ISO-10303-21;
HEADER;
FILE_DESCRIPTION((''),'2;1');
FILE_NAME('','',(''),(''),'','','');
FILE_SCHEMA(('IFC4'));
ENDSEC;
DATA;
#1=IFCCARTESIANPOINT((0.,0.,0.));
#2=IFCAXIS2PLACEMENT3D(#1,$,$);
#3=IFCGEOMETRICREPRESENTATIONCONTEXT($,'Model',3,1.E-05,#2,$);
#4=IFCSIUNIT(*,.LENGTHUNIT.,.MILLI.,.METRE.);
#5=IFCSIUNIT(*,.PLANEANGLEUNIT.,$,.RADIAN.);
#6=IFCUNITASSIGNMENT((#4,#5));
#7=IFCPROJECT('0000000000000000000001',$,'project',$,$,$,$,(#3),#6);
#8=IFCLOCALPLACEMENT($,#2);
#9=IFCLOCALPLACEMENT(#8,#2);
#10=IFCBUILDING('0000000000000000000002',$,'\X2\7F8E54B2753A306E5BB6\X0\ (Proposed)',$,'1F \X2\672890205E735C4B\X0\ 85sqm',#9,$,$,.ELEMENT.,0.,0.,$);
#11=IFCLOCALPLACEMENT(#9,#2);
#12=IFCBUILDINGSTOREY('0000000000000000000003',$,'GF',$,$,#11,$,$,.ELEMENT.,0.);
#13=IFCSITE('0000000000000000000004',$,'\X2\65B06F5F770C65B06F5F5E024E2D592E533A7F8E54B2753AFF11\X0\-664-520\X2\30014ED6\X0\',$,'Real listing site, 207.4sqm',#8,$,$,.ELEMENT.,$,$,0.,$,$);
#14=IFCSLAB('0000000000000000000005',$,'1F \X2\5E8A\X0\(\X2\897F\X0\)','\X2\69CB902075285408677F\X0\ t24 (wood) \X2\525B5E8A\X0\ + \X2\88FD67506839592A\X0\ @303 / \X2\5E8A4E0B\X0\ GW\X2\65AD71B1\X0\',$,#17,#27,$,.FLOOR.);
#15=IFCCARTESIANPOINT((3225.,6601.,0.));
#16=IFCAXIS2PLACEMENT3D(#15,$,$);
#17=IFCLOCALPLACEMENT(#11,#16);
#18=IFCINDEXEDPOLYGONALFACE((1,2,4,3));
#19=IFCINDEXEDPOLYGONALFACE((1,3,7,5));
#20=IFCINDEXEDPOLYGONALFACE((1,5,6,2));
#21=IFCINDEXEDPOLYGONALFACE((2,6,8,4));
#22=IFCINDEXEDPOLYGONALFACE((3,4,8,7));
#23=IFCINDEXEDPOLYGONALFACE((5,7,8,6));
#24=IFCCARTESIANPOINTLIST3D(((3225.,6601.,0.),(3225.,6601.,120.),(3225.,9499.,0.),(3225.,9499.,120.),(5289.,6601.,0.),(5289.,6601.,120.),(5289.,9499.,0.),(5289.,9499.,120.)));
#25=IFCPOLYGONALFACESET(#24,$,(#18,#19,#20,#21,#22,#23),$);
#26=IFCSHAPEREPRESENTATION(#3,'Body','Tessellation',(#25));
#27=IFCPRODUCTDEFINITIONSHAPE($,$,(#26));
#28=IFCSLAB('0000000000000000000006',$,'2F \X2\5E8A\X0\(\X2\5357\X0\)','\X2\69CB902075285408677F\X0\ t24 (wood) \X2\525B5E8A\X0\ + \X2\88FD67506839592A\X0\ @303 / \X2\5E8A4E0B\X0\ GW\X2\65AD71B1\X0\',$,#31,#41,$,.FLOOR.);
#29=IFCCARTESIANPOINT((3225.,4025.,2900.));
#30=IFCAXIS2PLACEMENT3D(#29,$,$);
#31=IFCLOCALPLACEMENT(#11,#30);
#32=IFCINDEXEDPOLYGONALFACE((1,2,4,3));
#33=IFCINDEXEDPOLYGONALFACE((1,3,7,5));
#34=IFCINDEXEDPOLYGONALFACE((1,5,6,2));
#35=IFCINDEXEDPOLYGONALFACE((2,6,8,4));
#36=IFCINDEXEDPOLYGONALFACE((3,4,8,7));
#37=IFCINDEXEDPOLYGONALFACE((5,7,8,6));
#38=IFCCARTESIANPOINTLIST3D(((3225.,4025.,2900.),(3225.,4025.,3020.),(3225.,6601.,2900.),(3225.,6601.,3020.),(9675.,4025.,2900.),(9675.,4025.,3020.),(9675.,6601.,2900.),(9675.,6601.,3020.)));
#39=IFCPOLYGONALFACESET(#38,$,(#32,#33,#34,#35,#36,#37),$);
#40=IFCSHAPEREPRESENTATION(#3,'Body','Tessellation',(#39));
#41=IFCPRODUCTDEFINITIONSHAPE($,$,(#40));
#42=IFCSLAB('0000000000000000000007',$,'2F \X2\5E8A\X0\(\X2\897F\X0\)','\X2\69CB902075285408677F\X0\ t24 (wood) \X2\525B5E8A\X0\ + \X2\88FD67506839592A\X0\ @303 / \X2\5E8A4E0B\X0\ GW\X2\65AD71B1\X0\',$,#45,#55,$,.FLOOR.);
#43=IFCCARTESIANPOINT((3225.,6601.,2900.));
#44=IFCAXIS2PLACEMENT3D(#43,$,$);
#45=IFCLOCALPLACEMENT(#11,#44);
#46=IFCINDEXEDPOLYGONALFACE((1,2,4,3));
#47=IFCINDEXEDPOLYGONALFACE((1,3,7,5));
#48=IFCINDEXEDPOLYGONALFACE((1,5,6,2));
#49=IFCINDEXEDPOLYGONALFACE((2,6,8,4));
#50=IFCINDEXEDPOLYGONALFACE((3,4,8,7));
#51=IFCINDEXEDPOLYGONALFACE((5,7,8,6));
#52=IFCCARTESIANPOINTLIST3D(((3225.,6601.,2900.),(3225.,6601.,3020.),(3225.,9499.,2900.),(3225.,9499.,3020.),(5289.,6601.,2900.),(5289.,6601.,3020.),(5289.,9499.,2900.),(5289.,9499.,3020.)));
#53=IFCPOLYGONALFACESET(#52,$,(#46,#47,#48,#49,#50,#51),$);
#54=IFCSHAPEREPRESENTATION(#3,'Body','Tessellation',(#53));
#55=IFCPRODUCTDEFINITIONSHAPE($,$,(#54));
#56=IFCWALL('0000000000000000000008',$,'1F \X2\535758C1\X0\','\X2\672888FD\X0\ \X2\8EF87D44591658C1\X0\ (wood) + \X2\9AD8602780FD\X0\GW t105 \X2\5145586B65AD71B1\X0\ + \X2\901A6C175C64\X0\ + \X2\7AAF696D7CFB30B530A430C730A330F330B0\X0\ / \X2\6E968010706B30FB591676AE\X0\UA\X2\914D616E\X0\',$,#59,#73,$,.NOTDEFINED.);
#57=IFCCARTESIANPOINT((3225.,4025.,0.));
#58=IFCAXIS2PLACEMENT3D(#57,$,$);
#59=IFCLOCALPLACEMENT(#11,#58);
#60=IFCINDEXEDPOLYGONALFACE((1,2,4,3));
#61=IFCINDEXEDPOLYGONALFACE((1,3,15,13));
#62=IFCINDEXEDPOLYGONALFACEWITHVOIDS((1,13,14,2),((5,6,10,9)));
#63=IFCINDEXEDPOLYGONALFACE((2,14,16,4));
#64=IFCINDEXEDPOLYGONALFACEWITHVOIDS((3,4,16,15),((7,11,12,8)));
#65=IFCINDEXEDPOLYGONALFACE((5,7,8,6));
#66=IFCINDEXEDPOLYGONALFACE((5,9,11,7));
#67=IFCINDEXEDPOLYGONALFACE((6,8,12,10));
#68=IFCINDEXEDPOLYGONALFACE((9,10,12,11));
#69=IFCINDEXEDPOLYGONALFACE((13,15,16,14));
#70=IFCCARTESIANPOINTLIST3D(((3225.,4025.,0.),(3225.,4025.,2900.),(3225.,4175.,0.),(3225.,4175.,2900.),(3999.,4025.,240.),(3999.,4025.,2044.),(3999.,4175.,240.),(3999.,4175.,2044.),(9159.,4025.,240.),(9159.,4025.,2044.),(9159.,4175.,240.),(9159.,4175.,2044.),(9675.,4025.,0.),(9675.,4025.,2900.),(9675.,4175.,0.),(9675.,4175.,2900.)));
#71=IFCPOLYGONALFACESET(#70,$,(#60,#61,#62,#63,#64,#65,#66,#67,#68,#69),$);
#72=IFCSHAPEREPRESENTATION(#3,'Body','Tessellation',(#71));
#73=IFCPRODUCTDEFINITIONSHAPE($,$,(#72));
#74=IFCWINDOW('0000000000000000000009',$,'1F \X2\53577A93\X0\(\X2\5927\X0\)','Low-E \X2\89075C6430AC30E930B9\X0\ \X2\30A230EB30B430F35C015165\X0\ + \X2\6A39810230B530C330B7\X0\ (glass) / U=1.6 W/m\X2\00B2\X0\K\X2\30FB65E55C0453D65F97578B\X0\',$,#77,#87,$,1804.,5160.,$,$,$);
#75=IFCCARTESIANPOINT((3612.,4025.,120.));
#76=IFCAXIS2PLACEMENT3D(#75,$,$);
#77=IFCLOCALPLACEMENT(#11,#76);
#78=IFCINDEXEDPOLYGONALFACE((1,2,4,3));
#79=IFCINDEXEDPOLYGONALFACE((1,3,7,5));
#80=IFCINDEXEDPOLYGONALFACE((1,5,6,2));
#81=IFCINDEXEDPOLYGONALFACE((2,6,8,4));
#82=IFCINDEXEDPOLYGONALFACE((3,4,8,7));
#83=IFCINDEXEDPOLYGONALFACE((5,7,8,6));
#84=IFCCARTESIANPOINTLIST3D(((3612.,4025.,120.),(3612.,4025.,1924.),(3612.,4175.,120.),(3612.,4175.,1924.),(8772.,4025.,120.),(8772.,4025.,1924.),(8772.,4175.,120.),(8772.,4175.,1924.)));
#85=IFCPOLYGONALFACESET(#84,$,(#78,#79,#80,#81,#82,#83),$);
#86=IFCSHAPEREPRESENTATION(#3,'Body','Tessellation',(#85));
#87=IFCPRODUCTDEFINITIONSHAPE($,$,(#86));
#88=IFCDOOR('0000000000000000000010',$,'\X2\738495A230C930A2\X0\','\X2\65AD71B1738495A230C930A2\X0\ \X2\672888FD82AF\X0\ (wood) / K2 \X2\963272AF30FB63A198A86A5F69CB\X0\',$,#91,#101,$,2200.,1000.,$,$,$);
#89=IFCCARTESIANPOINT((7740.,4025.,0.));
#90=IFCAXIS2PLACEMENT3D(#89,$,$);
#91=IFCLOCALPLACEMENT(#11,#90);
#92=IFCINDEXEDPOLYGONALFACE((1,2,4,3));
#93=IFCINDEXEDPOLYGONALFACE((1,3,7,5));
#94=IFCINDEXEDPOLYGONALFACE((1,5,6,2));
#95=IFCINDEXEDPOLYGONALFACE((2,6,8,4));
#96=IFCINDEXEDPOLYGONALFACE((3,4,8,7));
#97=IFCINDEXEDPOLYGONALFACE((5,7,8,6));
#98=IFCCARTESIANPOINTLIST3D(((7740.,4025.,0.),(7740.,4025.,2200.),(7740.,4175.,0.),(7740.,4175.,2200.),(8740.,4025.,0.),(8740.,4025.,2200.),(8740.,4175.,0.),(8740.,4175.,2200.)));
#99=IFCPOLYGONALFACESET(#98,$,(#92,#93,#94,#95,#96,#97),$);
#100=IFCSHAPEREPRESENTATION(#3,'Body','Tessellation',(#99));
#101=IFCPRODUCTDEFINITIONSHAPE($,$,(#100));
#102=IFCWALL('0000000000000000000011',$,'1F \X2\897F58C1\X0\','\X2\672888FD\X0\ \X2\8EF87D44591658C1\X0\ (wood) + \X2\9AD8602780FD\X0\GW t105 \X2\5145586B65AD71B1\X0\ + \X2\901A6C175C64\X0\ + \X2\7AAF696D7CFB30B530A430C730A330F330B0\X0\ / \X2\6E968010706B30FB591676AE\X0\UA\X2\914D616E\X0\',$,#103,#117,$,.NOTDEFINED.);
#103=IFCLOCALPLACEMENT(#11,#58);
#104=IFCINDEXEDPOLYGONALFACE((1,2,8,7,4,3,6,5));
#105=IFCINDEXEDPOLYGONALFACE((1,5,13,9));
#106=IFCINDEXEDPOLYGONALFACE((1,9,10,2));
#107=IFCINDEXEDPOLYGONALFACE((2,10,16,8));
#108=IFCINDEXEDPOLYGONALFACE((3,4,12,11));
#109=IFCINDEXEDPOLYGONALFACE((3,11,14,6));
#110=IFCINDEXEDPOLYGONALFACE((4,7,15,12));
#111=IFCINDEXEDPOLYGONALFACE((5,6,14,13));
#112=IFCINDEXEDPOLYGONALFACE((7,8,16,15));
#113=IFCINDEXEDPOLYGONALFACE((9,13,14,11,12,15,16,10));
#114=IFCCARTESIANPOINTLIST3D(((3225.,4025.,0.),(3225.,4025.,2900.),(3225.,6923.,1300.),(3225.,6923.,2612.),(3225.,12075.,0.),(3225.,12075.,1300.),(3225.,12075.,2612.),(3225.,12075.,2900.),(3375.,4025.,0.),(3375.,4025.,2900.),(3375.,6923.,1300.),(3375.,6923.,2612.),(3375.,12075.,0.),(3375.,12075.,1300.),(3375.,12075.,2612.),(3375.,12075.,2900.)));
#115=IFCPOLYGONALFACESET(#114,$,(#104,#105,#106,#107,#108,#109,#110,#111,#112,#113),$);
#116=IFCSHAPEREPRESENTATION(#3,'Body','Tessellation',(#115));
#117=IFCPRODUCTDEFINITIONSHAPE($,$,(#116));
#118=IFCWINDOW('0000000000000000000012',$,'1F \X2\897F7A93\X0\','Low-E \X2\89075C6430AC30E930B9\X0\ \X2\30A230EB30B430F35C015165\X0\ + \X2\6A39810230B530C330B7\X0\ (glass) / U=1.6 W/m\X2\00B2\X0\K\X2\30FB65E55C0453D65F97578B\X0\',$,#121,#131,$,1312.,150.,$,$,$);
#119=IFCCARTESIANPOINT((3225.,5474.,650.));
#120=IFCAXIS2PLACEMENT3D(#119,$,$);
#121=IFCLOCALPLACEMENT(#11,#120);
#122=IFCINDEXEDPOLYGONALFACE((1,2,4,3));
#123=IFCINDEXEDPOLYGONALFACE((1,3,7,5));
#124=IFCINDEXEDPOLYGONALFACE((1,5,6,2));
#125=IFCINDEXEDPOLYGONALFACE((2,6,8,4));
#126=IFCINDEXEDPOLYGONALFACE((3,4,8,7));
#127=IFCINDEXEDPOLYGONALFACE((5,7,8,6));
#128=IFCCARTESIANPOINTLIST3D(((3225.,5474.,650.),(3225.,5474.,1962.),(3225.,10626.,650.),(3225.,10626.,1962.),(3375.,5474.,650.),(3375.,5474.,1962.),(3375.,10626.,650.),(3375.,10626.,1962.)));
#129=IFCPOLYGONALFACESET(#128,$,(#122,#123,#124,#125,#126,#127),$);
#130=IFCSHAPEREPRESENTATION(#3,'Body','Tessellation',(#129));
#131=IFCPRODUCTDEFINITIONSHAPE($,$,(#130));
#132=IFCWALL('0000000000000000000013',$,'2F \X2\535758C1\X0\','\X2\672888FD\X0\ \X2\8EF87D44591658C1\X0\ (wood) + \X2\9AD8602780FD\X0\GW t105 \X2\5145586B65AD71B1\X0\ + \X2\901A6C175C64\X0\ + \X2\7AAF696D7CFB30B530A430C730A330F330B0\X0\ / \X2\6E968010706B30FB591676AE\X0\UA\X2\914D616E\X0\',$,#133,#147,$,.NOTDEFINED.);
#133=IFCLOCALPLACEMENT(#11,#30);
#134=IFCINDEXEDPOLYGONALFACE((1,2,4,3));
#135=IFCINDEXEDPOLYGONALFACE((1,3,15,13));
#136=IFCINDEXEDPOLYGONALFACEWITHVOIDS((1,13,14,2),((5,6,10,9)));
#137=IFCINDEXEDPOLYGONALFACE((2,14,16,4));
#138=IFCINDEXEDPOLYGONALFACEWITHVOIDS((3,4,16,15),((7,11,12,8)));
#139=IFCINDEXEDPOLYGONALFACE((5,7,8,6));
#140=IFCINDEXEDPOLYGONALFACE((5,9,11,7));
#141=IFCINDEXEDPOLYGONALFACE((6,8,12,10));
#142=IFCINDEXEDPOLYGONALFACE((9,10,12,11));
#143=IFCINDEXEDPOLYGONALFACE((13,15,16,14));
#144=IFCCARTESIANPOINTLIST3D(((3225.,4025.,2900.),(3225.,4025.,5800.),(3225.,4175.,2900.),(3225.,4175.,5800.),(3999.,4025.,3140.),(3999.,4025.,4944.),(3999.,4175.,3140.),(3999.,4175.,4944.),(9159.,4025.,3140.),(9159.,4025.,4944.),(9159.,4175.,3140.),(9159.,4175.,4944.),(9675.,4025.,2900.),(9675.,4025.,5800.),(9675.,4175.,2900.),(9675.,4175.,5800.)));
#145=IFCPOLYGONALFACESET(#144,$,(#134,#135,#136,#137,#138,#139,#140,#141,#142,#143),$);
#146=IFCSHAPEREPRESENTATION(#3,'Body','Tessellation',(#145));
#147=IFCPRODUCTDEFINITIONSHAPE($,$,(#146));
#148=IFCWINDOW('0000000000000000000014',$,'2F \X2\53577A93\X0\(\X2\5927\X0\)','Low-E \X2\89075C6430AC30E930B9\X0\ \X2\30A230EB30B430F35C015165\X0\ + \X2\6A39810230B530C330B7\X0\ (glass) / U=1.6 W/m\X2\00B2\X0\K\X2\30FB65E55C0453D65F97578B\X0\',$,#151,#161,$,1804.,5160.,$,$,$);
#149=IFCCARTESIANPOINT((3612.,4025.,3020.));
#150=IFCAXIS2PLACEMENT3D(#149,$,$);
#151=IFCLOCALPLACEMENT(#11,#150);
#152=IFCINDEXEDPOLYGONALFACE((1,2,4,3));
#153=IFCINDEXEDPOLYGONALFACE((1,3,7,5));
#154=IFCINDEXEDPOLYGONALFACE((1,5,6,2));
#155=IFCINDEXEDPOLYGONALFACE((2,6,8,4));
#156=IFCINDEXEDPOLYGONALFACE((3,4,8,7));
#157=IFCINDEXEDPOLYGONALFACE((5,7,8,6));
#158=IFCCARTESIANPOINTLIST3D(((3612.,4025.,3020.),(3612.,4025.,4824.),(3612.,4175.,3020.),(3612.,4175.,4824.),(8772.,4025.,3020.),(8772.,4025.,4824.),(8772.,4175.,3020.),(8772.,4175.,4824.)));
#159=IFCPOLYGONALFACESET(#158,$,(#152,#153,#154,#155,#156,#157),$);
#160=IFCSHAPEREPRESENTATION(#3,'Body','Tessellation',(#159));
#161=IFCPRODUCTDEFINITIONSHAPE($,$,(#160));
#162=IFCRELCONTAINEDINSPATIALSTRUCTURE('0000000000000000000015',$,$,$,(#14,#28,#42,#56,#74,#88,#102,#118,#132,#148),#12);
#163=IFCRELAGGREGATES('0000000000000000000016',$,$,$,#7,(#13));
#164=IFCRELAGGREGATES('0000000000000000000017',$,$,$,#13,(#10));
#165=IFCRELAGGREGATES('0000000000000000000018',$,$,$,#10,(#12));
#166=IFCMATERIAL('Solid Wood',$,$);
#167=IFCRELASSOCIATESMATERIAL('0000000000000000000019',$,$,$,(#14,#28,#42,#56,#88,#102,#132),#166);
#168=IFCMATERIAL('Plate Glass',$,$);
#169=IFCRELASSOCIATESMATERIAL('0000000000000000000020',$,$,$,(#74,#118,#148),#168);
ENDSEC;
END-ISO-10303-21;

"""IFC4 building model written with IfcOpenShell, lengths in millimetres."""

from ifc_helpers import new_model, si_unit, frame, frame_2d, origin, place, context, project, spatial, rectangle, extrude, material, element, fill, save


model = new_model("IFC4")

# Units and contexts
model_context = context("Model", 3, precision=1e-05, world=origin())
ifc_project = project(units=[si_unit("LENGTHUNIT", "METRE", prefix="MILLI"), si_unit("PLANEANGLEUNIT", "RADIAN")], contexts=[model_context])

# Site, building, storey
site_placement = place(None, origin())
site = spatial("IfcSite", under=ifc_project, at=site_placement, Name="新潟県新潟市中央区美咲町１-664-520、他", ObjectType="Real listing site, 207.4sqm", CompositionType="ELEMENT", RefElevation=0.0)
building_placement = place(site_placement, origin())
building = spatial("IfcBuilding", under=site, at=building_placement, Name="美咲町の家 (Proposed)", ObjectType="1F 木造平屋 85sqm", CompositionType="ELEMENT", ElevationOfRefHeight=0.0, ElevationOfTerrain=0.0)
storey_placement = place(building_placement, origin())
storey = spatial("IfcBuildingStorey", under=building, at=storey_placement, Name="GF", CompositionType="ELEMENT", Elevation=0.0)

# Slabs
ifc_material_1 = material(Name="Solid Wood")
slab_1_placement = place(storey_placement, frame((3225.0, 6601.0, 0.0)))
element("IfcSlab", 1, at=slab_1_placement, inside=storey, material=ifc_material_1, Name="1F 床(西)", Description="構造用合板 t24 (wood) 剛床 + 製材根太 @303 / 床下 GW断熱", PredefinedType="FLOOR", context=model_context, shape_type="SweptSolid", body=[
    extrude(rectangle(XDim=2064.0, YDim=2898.0, at=frame_2d((1032.0, 1449.0))), frame((3225.0, 6601.0, 0.0)), (0.0, 0.0, 1.0), 120.0),
])
slab_2_placement = place(storey_placement, frame((3225.0, 4025.0, 2900.0)))
element("IfcSlab", 2, at=slab_2_placement, inside=storey, material=ifc_material_1, Name="2F 床(南)", Description="構造用合板 t24 (wood) 剛床 + 製材根太 @303 / 床下 GW断熱", PredefinedType="FLOOR", context=model_context, shape_type="SweptSolid", body=[
    extrude(rectangle(XDim=6450.0, YDim=2576.0, at=frame_2d((3225.0, 1288.0))), frame((3225.0, 4025.0, 2900.0)), (0.0, 0.0, 1.0), 120.0),
])
slab_3_placement = place(storey_placement, frame((3225.0, 6601.0, 2900.0)))
element("IfcSlab", 3, at=slab_3_placement, inside=storey, material=ifc_material_1, Name="2F 床(西)", Description="構造用合板 t24 (wood) 剛床 + 製材根太 @303 / 床下 GW断熱", PredefinedType="FLOOR", context=model_context, shape_type="SweptSolid", body=[
    extrude(rectangle(XDim=2064.0, YDim=2898.0, at=frame_2d((1032.0, 1449.0))), frame((3225.0, 6601.0, 2900.0)), (0.0, 0.0, 1.0), 120.0),
])

# Wall, openings, window, door
wall_1_placement = place(storey_placement, frame((3225.0, 4025.0, 0.0)))
wall_1 = element("IfcWall", 4, at=wall_1_placement, inside=storey, material=ifc_material_1, Name="1F 南壁", Description="木製 軸組外壁 (wood) + 高性能GW t105 充填断熱 + 通気層 + 窯業系サイディング / 準耐火・外皮UA配慮", PredefinedType="NOTDEFINED", context=model_context, shape_type="SweptSolid", body=[
    extrude(rectangle(XDim=6450.0, YDim=150.0, at=frame_2d((3225.0, 75.0))), frame((3225.0, 4025.0, 0.0)), (0.0, 0.0, 1.0), 2900.0),
])
opening_1_placement = place(storey_placement, frame((3612.0, 4025.0, 120.0)))
opening_1 = element("IfcOpeningElement", 5, at=opening_1_placement, cuts=wall_1, PredefinedType="NOTDEFINED", context=model_context, shape_type="SweptSolid", body=[
    extrude(rectangle(XDim=5160.0, YDim=150.0, at=frame_2d((2580.0, 75.0))), frame((3612.0, 4025.0, 120.0)), (0.0, 0.0, 1.0), 1804.0),
])
opening_2_placement = place(storey_placement, frame((7740.0, 4025.0, 0.0)))
opening_2 = element("IfcOpeningElement", 6, at=opening_2_placement, cuts=wall_1, PredefinedType="NOTDEFINED", context=model_context, shape_type="SweptSolid", body=[
    extrude(rectangle(XDim=1000.0, YDim=150.0, at=frame_2d((500.0, 75.0))), frame((7740.0, 4025.0, 0.0)), (0.0, 0.0, 1.0), 2200.0),
])
ifc_material_2 = material(Name="Plate Glass")
window_1_placement = place(storey_placement, frame((3612.0, 4025.0, 120.0)))
window_1 = element("IfcWindow", 7, at=window_1_placement, inside=storey, material=ifc_material_2, Name="1F 南窓(大)", Description="Low-E 複層ガラス アルゴン封入 + 樹脂サッシ (glass) / U=1.6 W/m²K・日射取得型", OverallHeight=1804.0, OverallWidth=5160.0, context=model_context, shape_type="SweptSolid", body=[
    extrude(rectangle(XDim=5160.0, YDim=150.0, at=frame_2d((2580.0, 75.0))), frame((3612.0, 4025.0, 120.0)), (0.0, 0.0, 1.0), 1804.0),
])
fill(opening_1, window_1)
door_placement = place(storey_placement, frame((7740.0, 4025.0, 0.0)))
door = element("IfcDoor", 8, at=door_placement, inside=storey, material=ifc_material_1, Name="玄関ドア", Description="断熱玄関ドア 木製芯 (wood) / K2 防犯・採風機構", OverallHeight=2200.0, OverallWidth=1000.0, context=model_context, shape_type="SweptSolid", body=[
    extrude(rectangle(XDim=1000.0, YDim=150.0, at=frame_2d((500.0, 75.0))), frame((7740.0, 4025.0, 0.0)), (0.0, 0.0, 1.0), 2200.0),
])
fill(opening_2, door)

# Walls, openings, windows
wall_2_placement = place(storey_placement, frame((3225.0, 4025.0, 0.0)))
wall_2 = element("IfcWall", 9, at=wall_2_placement, inside=storey, material=ifc_material_1, Name="1F 西壁", Description="木製 軸組外壁 (wood) + 高性能GW t105 充填断熱 + 通気層 + 窯業系サイディング / 準耐火・外皮UA配慮", PredefinedType="NOTDEFINED", context=model_context, shape_type="SweptSolid", body=[
    extrude(rectangle(XDim=150.0, YDim=8050.0, at=frame_2d((75.0, 4025.0))), frame((3225.0, 4025.0, 0.0)), (0.0, 0.0, 1.0), 2900.0),
])
opening_3_placement = place(storey_placement, frame((3225.0, 5474.0, 650.0)))
opening_3 = element("IfcOpeningElement", 10, at=opening_3_placement, cuts=wall_2, PredefinedType="NOTDEFINED", context=model_context, shape_type="SweptSolid", body=[
    extrude(rectangle(XDim=150.0, YDim=5152.0, at=frame_2d((75.0, 2576.0))), frame((3225.0, 5474.0, 650.0)), (0.0, 0.0, 1.0), 1312.0),
])
window_2_placement = place(storey_placement, frame((3225.0, 5474.0, 650.0)))
window_2 = element("IfcWindow", 11, at=window_2_placement, inside=storey, material=ifc_material_2, Name="1F 西窓", Description="Low-E 複層ガラス アルゴン封入 + 樹脂サッシ (glass) / U=1.6 W/m²K・日射取得型", OverallHeight=1312.0, OverallWidth=150.0, context=model_context, shape_type="SweptSolid", body=[
    extrude(rectangle(XDim=150.0, YDim=5152.0, at=frame_2d((75.0, 2576.0))), frame((3225.0, 5474.0, 650.0)), (0.0, 0.0, 1.0), 1312.0),
])
fill(opening_3, window_2)
wall_3_placement = place(storey_placement, frame((3225.0, 4025.0, 2900.0)))
wall_3 = element("IfcWall", 12, at=wall_3_placement, inside=storey, material=ifc_material_1, Name="2F 南壁", Description="木製 軸組外壁 (wood) + 高性能GW t105 充填断熱 + 通気層 + 窯業系サイディング / 準耐火・外皮UA配慮", PredefinedType="NOTDEFINED", context=model_context, shape_type="SweptSolid", body=[
    extrude(rectangle(XDim=6450.0, YDim=150.0, at=frame_2d((3225.0, 75.0))), frame((3225.0, 4025.0, 2900.0)), (0.0, 0.0, 1.0), 2900.0),
])
opening_4_placement = place(storey_placement, frame((3612.0, 4025.0, 3020.0)))
opening_4 = element("IfcOpeningElement", 13, at=opening_4_placement, cuts=wall_3, PredefinedType="NOTDEFINED", context=model_context, shape_type="SweptSolid", body=[
    extrude(rectangle(XDim=5160.0, YDim=150.0, at=frame_2d((2580.0, 75.0))), frame((3612.0, 4025.0, 3020.0)), (0.0, 0.0, 1.0), 1804.0),
])
window_3_placement = place(storey_placement, frame((3612.0, 4025.0, 3020.0)))
window_3 = element("IfcWindow", 14, at=window_3_placement, inside=storey, material=ifc_material_2, Name="2F 南窓(大)", Description="Low-E 複層ガラス アルゴン封入 + 樹脂サッシ (glass) / U=1.6 W/m²K・日射取得型", OverallHeight=1804.0, OverallWidth=5160.0, context=model_context, shape_type="SweptSolid", body=[
    extrude(rectangle(XDim=5160.0, YDim=150.0, at=frame_2d((2580.0, 75.0))), frame((3612.0, 4025.0, 3020.0)), (0.0, 0.0, 1.0), 1804.0),
])
fill(opening_4, window_3)

save(model, "model.ifc")
